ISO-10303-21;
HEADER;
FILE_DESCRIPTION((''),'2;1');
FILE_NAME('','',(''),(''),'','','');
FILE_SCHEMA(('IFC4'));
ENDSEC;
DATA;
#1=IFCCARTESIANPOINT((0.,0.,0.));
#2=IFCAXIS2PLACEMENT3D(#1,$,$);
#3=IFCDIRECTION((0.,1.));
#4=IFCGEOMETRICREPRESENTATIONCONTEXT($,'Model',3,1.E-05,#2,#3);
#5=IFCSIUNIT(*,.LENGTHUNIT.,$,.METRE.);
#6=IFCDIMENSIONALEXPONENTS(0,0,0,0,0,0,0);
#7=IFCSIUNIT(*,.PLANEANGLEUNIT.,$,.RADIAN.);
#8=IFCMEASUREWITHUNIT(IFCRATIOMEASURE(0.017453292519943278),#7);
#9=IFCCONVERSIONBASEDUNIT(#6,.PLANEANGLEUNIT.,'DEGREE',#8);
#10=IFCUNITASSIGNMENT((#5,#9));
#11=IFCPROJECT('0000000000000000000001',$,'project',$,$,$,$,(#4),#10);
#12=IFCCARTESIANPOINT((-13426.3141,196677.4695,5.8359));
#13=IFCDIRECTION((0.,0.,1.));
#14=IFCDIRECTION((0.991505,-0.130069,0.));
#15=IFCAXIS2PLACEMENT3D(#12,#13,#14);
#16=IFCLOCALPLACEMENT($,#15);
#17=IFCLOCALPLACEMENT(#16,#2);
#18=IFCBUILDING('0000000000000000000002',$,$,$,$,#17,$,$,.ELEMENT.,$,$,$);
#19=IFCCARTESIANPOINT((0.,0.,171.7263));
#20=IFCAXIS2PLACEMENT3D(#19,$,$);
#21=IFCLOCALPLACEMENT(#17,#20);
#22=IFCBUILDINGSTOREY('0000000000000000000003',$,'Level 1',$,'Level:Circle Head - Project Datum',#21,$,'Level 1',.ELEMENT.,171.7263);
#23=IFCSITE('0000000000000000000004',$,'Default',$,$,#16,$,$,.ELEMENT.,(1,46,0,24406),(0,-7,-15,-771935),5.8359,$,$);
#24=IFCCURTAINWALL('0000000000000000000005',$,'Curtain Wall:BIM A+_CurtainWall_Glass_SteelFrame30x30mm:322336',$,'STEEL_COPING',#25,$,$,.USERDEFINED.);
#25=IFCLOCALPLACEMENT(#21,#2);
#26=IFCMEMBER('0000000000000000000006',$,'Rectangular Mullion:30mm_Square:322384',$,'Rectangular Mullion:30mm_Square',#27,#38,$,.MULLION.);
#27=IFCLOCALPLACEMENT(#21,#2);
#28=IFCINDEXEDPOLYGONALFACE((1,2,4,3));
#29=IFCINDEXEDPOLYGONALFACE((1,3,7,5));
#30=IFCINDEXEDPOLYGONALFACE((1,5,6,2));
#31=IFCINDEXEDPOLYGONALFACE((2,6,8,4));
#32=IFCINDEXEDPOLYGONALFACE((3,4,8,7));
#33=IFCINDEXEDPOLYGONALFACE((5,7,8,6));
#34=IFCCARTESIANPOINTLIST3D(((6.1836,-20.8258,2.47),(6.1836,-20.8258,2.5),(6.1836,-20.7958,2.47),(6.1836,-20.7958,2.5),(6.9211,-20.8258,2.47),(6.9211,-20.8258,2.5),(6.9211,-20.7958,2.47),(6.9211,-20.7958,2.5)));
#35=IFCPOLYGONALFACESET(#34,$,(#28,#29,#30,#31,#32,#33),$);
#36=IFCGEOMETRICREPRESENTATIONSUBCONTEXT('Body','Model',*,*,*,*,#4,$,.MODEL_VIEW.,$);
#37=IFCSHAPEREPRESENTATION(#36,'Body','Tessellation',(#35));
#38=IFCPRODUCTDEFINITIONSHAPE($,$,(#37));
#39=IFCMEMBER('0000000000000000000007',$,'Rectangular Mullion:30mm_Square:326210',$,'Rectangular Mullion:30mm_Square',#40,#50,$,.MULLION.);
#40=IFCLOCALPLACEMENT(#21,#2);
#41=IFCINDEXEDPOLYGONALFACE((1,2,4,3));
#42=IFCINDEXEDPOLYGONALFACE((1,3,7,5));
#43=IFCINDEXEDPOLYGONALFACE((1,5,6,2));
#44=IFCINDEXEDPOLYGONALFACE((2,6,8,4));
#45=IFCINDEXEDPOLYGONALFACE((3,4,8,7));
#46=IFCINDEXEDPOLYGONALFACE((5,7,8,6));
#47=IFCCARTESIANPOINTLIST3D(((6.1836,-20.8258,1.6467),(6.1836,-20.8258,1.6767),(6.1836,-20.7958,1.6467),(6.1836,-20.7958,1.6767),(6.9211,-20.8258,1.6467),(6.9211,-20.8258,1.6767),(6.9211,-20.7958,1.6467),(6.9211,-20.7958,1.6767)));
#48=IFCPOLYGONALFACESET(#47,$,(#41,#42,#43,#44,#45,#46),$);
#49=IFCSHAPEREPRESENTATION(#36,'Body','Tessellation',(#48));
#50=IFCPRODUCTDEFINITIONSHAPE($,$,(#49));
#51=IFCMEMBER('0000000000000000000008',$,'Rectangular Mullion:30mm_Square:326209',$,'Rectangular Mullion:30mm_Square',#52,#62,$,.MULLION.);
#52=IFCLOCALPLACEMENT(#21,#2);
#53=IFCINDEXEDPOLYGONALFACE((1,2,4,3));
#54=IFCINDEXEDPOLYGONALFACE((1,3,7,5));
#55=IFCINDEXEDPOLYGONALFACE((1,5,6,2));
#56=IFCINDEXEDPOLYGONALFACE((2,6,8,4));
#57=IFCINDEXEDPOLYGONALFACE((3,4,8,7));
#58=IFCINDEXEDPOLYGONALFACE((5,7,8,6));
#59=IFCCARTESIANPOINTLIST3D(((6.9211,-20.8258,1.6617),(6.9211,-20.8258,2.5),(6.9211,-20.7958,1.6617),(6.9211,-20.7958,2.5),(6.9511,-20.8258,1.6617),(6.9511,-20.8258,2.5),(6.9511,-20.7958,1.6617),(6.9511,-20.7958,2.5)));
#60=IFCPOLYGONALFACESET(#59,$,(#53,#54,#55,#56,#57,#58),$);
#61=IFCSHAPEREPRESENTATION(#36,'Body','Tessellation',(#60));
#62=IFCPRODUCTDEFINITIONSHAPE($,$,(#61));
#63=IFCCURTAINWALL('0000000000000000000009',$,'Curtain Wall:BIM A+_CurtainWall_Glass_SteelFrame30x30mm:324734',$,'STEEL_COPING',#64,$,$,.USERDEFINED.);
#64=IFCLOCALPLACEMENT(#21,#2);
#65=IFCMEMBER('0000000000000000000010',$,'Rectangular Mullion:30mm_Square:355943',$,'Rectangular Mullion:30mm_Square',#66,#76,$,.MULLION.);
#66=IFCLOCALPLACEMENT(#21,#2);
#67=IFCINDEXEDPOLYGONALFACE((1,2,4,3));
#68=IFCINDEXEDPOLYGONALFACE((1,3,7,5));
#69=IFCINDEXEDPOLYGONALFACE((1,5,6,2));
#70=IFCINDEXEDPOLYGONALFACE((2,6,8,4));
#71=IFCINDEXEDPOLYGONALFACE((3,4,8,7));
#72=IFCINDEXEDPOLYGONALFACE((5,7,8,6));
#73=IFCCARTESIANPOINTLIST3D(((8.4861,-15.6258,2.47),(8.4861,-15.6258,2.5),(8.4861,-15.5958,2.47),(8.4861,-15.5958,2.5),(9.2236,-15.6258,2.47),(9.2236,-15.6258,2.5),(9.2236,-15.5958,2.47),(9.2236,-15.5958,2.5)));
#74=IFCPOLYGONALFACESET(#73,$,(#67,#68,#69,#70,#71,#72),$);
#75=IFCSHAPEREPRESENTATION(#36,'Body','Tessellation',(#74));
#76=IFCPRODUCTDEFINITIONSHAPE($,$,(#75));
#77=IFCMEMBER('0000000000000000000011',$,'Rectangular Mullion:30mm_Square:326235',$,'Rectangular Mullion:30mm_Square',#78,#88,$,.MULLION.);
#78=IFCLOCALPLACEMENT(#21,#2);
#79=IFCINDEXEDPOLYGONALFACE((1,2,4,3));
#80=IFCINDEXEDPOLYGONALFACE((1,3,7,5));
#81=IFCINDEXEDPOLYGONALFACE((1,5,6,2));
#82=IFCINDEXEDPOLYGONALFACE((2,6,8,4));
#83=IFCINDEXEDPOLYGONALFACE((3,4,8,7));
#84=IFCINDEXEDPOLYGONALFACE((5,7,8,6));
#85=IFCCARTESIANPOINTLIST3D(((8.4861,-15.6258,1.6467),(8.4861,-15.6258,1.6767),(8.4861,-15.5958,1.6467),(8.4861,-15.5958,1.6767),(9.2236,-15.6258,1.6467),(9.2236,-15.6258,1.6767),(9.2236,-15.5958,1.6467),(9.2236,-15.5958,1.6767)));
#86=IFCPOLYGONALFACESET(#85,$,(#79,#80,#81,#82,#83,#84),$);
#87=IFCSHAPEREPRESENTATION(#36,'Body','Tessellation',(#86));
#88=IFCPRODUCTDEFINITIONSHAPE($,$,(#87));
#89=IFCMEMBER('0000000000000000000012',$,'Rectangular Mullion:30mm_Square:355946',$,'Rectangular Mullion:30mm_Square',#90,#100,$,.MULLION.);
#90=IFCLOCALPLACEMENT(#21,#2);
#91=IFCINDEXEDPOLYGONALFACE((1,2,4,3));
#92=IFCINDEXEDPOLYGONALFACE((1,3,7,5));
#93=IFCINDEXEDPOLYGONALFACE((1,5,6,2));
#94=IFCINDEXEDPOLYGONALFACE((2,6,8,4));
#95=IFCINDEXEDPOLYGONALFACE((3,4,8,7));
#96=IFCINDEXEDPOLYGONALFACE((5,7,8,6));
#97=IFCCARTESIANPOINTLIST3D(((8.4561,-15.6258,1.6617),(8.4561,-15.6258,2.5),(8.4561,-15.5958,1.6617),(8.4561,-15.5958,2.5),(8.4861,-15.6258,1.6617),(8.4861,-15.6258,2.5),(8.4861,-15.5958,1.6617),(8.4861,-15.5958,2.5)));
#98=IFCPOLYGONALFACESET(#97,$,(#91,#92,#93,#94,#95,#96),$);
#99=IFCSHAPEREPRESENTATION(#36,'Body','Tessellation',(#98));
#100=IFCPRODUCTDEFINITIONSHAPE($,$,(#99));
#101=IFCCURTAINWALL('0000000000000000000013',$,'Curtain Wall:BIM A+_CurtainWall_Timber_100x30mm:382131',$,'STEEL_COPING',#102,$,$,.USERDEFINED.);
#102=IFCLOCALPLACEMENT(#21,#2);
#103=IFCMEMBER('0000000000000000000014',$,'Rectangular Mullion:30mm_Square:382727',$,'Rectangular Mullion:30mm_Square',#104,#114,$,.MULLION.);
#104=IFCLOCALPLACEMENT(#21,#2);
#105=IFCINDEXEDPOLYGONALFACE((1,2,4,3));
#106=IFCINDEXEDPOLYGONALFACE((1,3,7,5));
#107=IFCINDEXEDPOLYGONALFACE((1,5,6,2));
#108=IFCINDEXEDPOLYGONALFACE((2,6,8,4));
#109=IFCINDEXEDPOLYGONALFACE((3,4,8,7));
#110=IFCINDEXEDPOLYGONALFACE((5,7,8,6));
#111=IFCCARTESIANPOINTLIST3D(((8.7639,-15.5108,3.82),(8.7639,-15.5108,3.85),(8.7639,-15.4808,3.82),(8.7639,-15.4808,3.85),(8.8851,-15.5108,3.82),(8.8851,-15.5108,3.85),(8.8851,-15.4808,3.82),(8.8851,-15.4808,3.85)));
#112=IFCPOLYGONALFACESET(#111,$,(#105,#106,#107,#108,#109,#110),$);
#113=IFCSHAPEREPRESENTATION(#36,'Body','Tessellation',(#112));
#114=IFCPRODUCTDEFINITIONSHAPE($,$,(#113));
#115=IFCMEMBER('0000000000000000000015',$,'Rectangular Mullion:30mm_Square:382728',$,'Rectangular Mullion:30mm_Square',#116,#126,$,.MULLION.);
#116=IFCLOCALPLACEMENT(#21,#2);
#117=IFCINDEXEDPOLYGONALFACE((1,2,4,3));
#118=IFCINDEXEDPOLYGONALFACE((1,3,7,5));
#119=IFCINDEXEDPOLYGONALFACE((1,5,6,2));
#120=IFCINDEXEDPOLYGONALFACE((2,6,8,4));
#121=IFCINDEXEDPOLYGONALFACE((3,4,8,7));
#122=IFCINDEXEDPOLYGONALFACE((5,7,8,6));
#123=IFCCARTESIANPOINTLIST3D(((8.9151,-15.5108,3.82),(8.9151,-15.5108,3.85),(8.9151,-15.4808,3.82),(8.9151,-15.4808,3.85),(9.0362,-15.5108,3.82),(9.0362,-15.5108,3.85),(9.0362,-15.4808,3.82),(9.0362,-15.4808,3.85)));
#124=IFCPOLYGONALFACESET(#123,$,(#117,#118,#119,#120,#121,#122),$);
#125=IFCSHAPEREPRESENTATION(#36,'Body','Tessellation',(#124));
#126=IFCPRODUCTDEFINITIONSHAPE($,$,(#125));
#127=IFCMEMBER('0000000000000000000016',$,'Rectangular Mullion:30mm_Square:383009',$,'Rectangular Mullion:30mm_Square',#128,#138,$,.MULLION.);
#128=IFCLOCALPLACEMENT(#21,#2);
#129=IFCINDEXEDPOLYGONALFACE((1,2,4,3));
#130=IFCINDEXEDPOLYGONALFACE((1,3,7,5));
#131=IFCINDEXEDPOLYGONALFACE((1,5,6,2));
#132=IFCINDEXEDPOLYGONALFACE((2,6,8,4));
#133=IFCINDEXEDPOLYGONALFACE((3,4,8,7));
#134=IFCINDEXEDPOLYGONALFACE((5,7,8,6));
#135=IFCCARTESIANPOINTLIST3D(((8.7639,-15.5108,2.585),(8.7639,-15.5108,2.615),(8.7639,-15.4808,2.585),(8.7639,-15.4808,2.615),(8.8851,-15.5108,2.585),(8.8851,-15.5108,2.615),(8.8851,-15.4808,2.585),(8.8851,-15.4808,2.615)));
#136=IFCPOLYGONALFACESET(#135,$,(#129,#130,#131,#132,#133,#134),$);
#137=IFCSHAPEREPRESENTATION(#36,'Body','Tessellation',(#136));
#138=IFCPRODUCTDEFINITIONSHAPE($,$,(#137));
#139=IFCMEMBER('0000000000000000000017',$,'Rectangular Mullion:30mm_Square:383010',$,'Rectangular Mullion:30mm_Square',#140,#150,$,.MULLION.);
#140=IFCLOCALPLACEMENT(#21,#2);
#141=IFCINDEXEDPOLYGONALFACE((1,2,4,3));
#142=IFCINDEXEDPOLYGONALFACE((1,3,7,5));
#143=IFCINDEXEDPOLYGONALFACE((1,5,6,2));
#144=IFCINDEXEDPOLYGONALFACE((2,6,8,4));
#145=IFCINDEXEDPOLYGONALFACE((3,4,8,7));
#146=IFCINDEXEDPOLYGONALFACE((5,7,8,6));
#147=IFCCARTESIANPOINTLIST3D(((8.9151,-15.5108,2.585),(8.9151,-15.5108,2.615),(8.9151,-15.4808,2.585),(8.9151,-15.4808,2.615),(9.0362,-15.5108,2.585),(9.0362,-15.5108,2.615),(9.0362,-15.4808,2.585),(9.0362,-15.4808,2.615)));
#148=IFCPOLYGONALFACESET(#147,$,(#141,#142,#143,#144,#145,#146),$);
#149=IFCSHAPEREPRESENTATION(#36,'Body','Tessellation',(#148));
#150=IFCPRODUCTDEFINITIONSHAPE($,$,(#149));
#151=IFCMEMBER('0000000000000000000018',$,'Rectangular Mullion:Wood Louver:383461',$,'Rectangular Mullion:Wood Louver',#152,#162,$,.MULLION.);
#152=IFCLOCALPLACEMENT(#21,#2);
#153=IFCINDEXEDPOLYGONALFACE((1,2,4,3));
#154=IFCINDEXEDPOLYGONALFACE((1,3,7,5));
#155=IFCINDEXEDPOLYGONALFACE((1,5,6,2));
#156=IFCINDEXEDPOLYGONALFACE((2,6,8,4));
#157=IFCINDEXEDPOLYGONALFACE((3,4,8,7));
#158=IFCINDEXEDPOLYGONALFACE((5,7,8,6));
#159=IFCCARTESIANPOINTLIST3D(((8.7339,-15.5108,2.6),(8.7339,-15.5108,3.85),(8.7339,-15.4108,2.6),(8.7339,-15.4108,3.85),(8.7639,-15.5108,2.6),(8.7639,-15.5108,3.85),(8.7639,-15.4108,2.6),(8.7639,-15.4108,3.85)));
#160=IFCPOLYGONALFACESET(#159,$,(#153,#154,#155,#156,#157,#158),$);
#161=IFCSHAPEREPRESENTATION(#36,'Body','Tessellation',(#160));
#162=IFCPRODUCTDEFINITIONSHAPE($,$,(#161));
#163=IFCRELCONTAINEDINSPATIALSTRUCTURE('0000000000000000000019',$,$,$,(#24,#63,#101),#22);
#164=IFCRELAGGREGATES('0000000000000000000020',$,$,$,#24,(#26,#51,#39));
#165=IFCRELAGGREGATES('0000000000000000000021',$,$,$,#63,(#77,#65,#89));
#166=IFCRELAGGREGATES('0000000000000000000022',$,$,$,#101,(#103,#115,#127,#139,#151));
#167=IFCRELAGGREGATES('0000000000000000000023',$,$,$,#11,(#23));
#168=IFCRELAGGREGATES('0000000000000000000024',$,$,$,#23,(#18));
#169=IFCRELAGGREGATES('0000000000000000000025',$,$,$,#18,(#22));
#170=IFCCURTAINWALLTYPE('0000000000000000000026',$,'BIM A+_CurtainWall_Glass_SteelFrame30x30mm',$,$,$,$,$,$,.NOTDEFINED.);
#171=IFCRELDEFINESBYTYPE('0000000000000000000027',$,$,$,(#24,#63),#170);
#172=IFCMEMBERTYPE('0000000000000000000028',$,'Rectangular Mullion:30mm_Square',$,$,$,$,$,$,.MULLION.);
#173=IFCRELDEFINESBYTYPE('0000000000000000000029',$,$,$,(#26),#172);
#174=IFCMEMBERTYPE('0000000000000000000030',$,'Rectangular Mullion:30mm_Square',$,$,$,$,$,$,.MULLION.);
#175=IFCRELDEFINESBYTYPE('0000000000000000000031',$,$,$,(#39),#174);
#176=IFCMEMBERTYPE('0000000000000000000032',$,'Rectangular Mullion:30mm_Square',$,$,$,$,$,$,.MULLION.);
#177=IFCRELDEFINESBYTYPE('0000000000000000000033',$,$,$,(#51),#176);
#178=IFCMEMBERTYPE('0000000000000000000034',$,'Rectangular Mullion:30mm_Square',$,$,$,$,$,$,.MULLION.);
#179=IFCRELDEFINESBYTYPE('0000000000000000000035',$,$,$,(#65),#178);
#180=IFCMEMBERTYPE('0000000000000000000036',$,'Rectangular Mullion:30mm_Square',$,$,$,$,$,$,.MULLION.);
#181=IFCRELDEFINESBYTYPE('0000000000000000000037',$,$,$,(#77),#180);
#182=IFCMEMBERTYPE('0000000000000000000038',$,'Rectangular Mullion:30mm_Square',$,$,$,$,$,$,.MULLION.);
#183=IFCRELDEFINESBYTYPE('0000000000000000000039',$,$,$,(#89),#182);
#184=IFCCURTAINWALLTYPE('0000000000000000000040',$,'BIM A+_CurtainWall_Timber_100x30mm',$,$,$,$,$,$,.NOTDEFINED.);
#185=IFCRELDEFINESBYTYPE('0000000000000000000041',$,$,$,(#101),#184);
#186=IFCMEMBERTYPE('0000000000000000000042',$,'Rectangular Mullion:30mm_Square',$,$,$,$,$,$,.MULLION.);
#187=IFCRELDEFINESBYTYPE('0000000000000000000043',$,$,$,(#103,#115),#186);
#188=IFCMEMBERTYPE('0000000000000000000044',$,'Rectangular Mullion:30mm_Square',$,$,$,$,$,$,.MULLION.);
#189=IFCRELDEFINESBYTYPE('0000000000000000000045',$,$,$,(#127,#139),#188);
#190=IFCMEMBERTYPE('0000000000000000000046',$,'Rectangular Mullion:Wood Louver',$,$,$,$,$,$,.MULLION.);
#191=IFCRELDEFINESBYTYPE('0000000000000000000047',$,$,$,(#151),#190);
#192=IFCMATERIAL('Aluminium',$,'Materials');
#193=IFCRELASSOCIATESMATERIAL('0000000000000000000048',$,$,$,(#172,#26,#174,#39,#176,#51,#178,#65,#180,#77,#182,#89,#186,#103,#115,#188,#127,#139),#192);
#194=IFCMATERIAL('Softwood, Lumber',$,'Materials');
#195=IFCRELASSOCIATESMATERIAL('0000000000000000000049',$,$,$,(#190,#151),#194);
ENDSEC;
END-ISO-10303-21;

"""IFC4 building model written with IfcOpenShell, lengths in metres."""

from ifc_helpers import new_model, entity, si_unit, converted_unit, direction, frame, origin, place, context, subcontext, project, spatial, indexed_curve, outline, extrude, source, transform, mapped, material, type_object, type_shapes, element, aggregate, save


model = new_model("IFC4")

# Units and contexts
model_context = context("Model", 3, precision=1e-05, world=origin(), true_north=direction((0.0, 1.0)))
body_context = subcontext(model_context, "Body", "Model", "MODEL_VIEW")
ifc_project = project(units=[si_unit("LENGTHUNIT", "METRE"), converted_unit("PLANEANGLEUNIT", "DEGREE", entity("IfcRatioMeasure", 0.017453292519943278), si_unit("PLANEANGLEUNIT", "RADIAN"), dimensions=[0, 0, 0, 0, 0, 0, 0])], contexts=[model_context])

# Site, building, storey
site_placement = place(None, frame((-13426.3141, 196677.4695, 5.8359), z_axis=(0.0, 0.0, 1.0), x_axis=(0.991505, -0.130069, 0.0)))
site = spatial("IfcSite", under=ifc_project, at=site_placement, Name="Default", CompositionType="ELEMENT", RefLatitude=(1, 46, 0, 24406), RefLongitude=(0, -7, -15, -771935), RefElevation=5.8359)
building_placement = place(site_placement, origin())
building = spatial("IfcBuilding", under=site, at=building_placement, CompositionType="ELEMENT")
storey_placement = place(building_placement, frame((0.0, 0.0, 171.7263)))
storey = spatial("IfcBuildingStorey", under=building, at=storey_placement, Name="Level 1", ObjectType="Level:Circle Head - Project Datum", LongName="Level 1", CompositionType="ELEMENT", Elevation=171.7263)

# Curtain walls, members
curtain_wall_type_1 = type_object("IfcCurtainWallType", Name="BIM A+_CurtainWall_Glass_SteelFrame30x30mm", PredefinedType="NOTDEFINED")
curtain_wall_1_placement = place(storey_placement, frame((0.0, 0.0, -171.7263)))
curtain_wall_1 = element("IfcCurtainWall", 1, at=curtain_wall_1_placement, inside=storey, type_object=curtain_wall_type_1, Name="Curtain Wall:BIM A+_CurtainWall_Glass_SteelFrame30x30mm:322336", ObjectType="STEEL_COPING", PredefinedType="USERDEFINED")
ifc_material_1 = material(Name="Aluminium", Category="Materials")
member_type_1 = type_object("IfcMemberType", Name="Rectangular Mullion:30mm_Square", PredefinedType="MULLION", material=ifc_material_1)
shared_shape_1 = source(origin(), body_context, "Body", "SweptSolid", [
    extrude(outline(indexed_curve([(-0.015, -0.015), (0.015, -0.015), (0.015, 0.015), (-0.015, 0.015), (-0.015, -0.015)], self_intersect=False)), frame((-0.015, 0.0, -0.7375), z_axis=(0.0, 0.0, 1.0), x_axis=(0.0, -1.0, 0.0)), (0.0, 0.0, 1.0), 0.7375),
])
type_shapes(member_type_1, [shared_shape_1])
member_1_placement = place(curtain_wall_1_placement, frame((6.9211, -20.8108, 174.2263), z_axis=(1.0, 0.0, 0.0), x_axis=(0.0, 0.0, 1.0)))
member_1 = element("IfcMember", 2, at=member_1_placement, type_object=member_type_1, material=ifc_material_1, Name="Rectangular Mullion:30mm_Square:322384", ObjectType="Rectangular Mullion:30mm_Square", PredefinedType="MULLION", context=body_context, shape_type="MappedRepresentation", body=[
    mapped(shared_shape_1, transform((0.0, 0.0, 0.0), scale=1.0)),
])
member_type_2 = type_object("IfcMemberType", Name="Rectangular Mullion:30mm_Square", PredefinedType="MULLION", material=ifc_material_1)
shared_shape_2 = source(origin(), body_context, "Body", "SweptSolid", [
    extrude(outline(indexed_curve([(-0.015, -0.015), (0.015, -0.015), (0.015, 0.015), (-0.015, 0.015), (-0.015, -0.015)], self_intersect=False)), frame((0.0, 0.0, -0.7375), z_axis=(0.0, 0.0, 1.0), x_axis=(0.0, -1.0, 0.0)), (0.0, 0.0, 1.0), 0.7375),
])
type_shapes(member_type_2, [shared_shape_2])
member_2_placement = place(curtain_wall_1_placement, frame((6.9211, -20.8108, 173.3879), z_axis=(1.0, 0.0, 0.0), x_axis=(0.0, 0.0, 1.0)))
member_2 = element("IfcMember", 3, at=member_2_placement, type_object=member_type_2, material=ifc_material_1, Name="Rectangular Mullion:30mm_Square:326210", ObjectType="Rectangular Mullion:30mm_Square", PredefinedType="MULLION", context=body_context, shape_type="MappedRepresentation", body=[
    mapped(shared_shape_2, transform((0.0, 0.0, 0.0), scale=1.0)),
])
member_type_3 = type_object("IfcMemberType", Name="Rectangular Mullion:30mm_Square", PredefinedType="MULLION", material=ifc_material_1)
shared_shape_3 = source(origin(), body_context, "Body", "SweptSolid", [
    extrude(outline(indexed_curve([(-0.015, -0.015), (0.015, -0.015), (0.015, 0.015), (-0.015, 0.015), (-0.015, -0.015)], self_intersect=False)), frame((0.0, 0.0, -0.8383), z_axis=(0.0, 0.0, 1.0), x_axis=(0.0, -1.0, 0.0)), (0.0, 0.0, 1.0), 0.8383),
])
type_shapes(member_type_3, [shared_shape_3])
member_3_placement = place(curtain_wall_1_placement, frame((6.9361, -20.8108, 173.3879), z_axis=(0.0, 0.0, -1.0), x_axis=(1.0, 0.0, 0.0)))
member_3 = element("IfcMember", 4, at=member_3_placement, type_object=member_type_3, material=ifc_material_1, Name="Rectangular Mullion:30mm_Square:326209", ObjectType="Rectangular Mullion:30mm_Square", PredefinedType="MULLION", context=body_context, shape_type="MappedRepresentation", body=[
    mapped(shared_shape_3, transform((0.0, 0.0, 0.0), scale=1.0)),
])
curtain_wall_2_placement = place(storey_placement, frame((0.0, 0.0, -171.7263)))
curtain_wall_2 = element("IfcCurtainWall", 5, at=curtain_wall_2_placement, inside=storey, type_object=curtain_wall_type_1, Name="Curtain Wall:BIM A+_CurtainWall_Glass_SteelFrame30x30mm:324734", ObjectType="STEEL_COPING", PredefinedType="USERDEFINED")
member_type_4 = type_object("IfcMemberType", Name="Rectangular Mullion:30mm_Square", PredefinedType="MULLION", material=ifc_material_1)
shared_shape_4 = source(origin(), body_context, "Body", "SweptSolid", [
    extrude(outline(indexed_curve([(-0.015, -0.015), (0.015, -0.015), (0.015, 0.015), (-0.015, 0.015), (-0.015, -0.015)], self_intersect=False)), frame((-0.015, 0.0, -0.7375), z_axis=(0.0, 0.0, 1.0), x_axis=(0.0, -1.0, 0.0)), (0.0, 0.0, 1.0), 0.7375),
])
type_shapes(member_type_4, [shared_shape_4])
member_4_placement = place(curtain_wall_2_placement, frame((8.4861, -15.6108, 174.2263), z_axis=(-1.0, 0.0, 0.0), x_axis=(0.0, 0.0, 1.0)))
member_4 = element("IfcMember", 6, at=member_4_placement, type_object=member_type_4, material=ifc_material_1, Name="Rectangular Mullion:30mm_Square:355943", ObjectType="Rectangular Mullion:30mm_Square", PredefinedType="MULLION", context=body_context, shape_type="MappedRepresentation", body=[
    mapped(shared_shape_4, transform((0.0, 0.0, 0.0), scale=1.0)),
])
member_type_5 = type_object("IfcMemberType", Name="Rectangular Mullion:30mm_Square", PredefinedType="MULLION", material=ifc_material_1)
shared_shape_5 = source(origin(), body_context, "Body", "SweptSolid", [
    extrude(outline(indexed_curve([(-0.015, -0.015), (0.015, -0.015), (0.015, 0.015), (-0.015, 0.015), (-0.015, -0.015)], self_intersect=False)), frame((0.0, 0.0, -0.7375), z_axis=(0.0, 0.0, 1.0), x_axis=(0.0, -1.0, 0.0)), (0.0, 0.0, 1.0), 0.7375),
])
type_shapes(member_type_5, [shared_shape_5])
member_5_placement = place(curtain_wall_2_placement, frame((8.4861, -15.6108, 173.3879), z_axis=(-1.0, 0.0, 0.0), x_axis=(0.0, 0.0, 1.0)))
member_5 = element("IfcMember", 7, at=member_5_placement, type_object=member_type_5, material=ifc_material_1, Name="Rectangular Mullion:30mm_Square:326235", ObjectType="Rectangular Mullion:30mm_Square", PredefinedType="MULLION", context=body_context, shape_type="MappedRepresentation", body=[
    mapped(shared_shape_5, transform((0.0, 0.0, 0.0), scale=1.0)),
])
member_type_6 = type_object("IfcMemberType", Name="Rectangular Mullion:30mm_Square", PredefinedType="MULLION", material=ifc_material_1)
shared_shape_6 = source(origin(), body_context, "Body", "SweptSolid", [
    extrude(outline(indexed_curve([(-0.015, -0.015), (0.015, -0.015), (0.015, 0.015), (-0.015, 0.015), (-0.015, -0.015)], self_intersect=False)), frame((0.0, 0.0, -0.8383), z_axis=(0.0, 0.0, 1.0), x_axis=(0.0, -1.0, 0.0)), (0.0, 0.0, 1.0), 0.8383),
])
type_shapes(member_type_6, [shared_shape_6])
member_6_placement = place(curtain_wall_2_placement, frame((8.4711, -15.6108, 173.3879), z_axis=(0.0, 0.0, -1.0), x_axis=(-1.0, 0.0, 0.0)))
member_6 = element("IfcMember", 8, at=member_6_placement, type_object=member_type_6, material=ifc_material_1, Name="Rectangular Mullion:30mm_Square:355946", ObjectType="Rectangular Mullion:30mm_Square", PredefinedType="MULLION", context=body_context, shape_type="MappedRepresentation", body=[
    mapped(shared_shape_6, transform((0.0, 0.0, 0.0), scale=1.0)),
])
curtain_wall_type_2 = type_object("IfcCurtainWallType", Name="BIM A+_CurtainWall_Timber_100x30mm", PredefinedType="NOTDEFINED")
curtain_wall_3_placement = place(storey_placement, frame((0.0, 0.0, -171.7263)))
curtain_wall_3 = element("IfcCurtainWall", 9, at=curtain_wall_3_placement, inside=storey, type_object=curtain_wall_type_2, Name="Curtain Wall:BIM A+_CurtainWall_Timber_100x30mm:382131", ObjectType="STEEL_COPING", PredefinedType="USERDEFINED")
member_type_7 = type_object("IfcMemberType", Name="Rectangular Mullion:30mm_Square", PredefinedType="MULLION", material=ifc_material_1)
shared_shape_7 = source(origin(), body_context, "Body", "SweptSolid", [
    extrude(outline(indexed_curve([(-0.015, -0.015), (0.015, -0.015), (0.015, 0.015), (-0.015, 0.015), (-0.015, -0.015)], self_intersect=False)), frame((-0.015, 0.0, -0.1212), z_axis=(0.0, 0.0, 1.0), x_axis=(0.0, -1.0, 0.0)), (0.0, 0.0, 1.0), 0.1212),
])
type_shapes(member_type_7, [shared_shape_7])
member_7_placement = place(curtain_wall_3_placement, frame((8.8851, -15.4958, 175.5763), z_axis=(1.0, 0.0, 0.0), x_axis=(0.0, 0.0, 1.0)))
member_7 = element("IfcMember", 10, at=member_7_placement, type_object=member_type_7, material=ifc_material_1, Name="Rectangular Mullion:30mm_Square:382727", ObjectType="Rectangular Mullion:30mm_Square", PredefinedType="MULLION", context=body_context, shape_type="MappedRepresentation", body=[
    mapped(shared_shape_7, transform((0.0, 0.0, 0.0), scale=1.0)),
])
member_8_placement = place(curtain_wall_3_placement, frame((9.0362, -15.4958, 175.5763), z_axis=(1.0, 0.0, 0.0), x_axis=(0.0, 0.0, 1.0)))
member_8 = element("IfcMember", 11, at=member_8_placement, type_object=member_type_7, material=ifc_material_1, Name="Rectangular Mullion:30mm_Square:382728", ObjectType="Rectangular Mullion:30mm_Square", PredefinedType="MULLION", context=body_context, shape_type="MappedRepresentation", body=[
    mapped(shared_shape_7, transform((0.0, 0.0, 0.0), scale=1.0)),
])
member_type_8 = type_object("IfcMemberType", Name="Rectangular Mullion:30mm_Square", PredefinedType="MULLION", material=ifc_material_1)
shared_shape_8 = source(origin(), body_context, "Body", "SweptSolid", [
    extrude(outline(indexed_curve([(-0.015, -0.015), (0.015, -0.015), (0.015, 0.015), (-0.015, 0.015), (-0.015, -0.015)], self_intersect=False)), frame((0.0, 0.0, -0.1212), z_axis=(0.0, 0.0, 1.0), x_axis=(0.0, -1.0, 0.0)), (0.0, 0.0, 1.0), 0.1212),
])
type_shapes(member_type_8, [shared_shape_8])
member_9_placement = place(curtain_wall_3_placement, frame((8.8851, -15.4958, 174.3263), z_axis=(1.0, 0.0, 0.0), x_axis=(0.0, 0.0, 1.0)))
member_9 = element("IfcMember", 12, at=member_9_placement, type_object=member_type_8, material=ifc_material_1, Name="Rectangular Mullion:30mm_Square:383009", ObjectType="Rectangular Mullion:30mm_Square", PredefinedType="MULLION", context=body_context, shape_type="MappedRepresentation", body=[
    mapped(shared_shape_8, transform((0.0, 0.0, 0.0), scale=1.0)),
])
member_10_placement = place(curtain_wall_3_placement, frame((9.0362, -15.4958, 174.3263), z_axis=(1.0, 0.0, 0.0), x_axis=(0.0, 0.0, 1.0)))
member_10 = element("IfcMember", 13, at=member_10_placement, type_object=member_type_8, material=ifc_material_1, Name="Rectangular Mullion:30mm_Square:383010", ObjectType="Rectangular Mullion:30mm_Square", PredefinedType="MULLION", context=body_context, shape_type="MappedRepresentation", body=[
    mapped(shared_shape_8, transform((0.0, 0.0, 0.0), scale=1.0)),
])
ifc_material_2 = material(Name="Softwood, Lumber", Category="Materials")
member_type_9 = type_object("IfcMemberType", Name="Rectangular Mullion:Wood Louver", PredefinedType="MULLION", material=ifc_material_2)
shared_shape_9 = source(origin(), body_context, "Body", "SweptSolid", [
    extrude(outline(indexed_curve([(-0.05, -0.015), (0.05, -0.015), (0.05, 0.015), (-0.05, 0.015), (-0.05, -0.015)], self_intersect=False)), frame((0.0, -0.035, -1.25), z_axis=(0.0, 0.0, 1.0), x_axis=(0.0, -1.0, 0.0)), (0.0, 0.0, 1.0), 1.25),
])
type_shapes(member_type_9, [shared_shape_9])
member_11_placement = place(curtain_wall_3_placement, frame((8.7489, -15.4958, 174.3263), z_axis=(0.0, 0.0, -1.0), x_axis=(1.0, 0.0, 0.0)))
member_11 = element("IfcMember", 14, at=member_11_placement, type_object=member_type_9, material=ifc_material_2, Name="Rectangular Mullion:Wood Louver:383461", ObjectType="Rectangular Mullion:Wood Louver", PredefinedType="MULLION", context=body_context, shape_type="MappedRepresentation", body=[
    mapped(shared_shape_9, transform((0.0, 0.0, 0.0), scale=1.0)),
])

aggregate(curtain_wall_1, [member_1, member_3, member_2])
aggregate(curtain_wall_2, [member_5, member_4, member_6])
aggregate(curtain_wall_3, [member_7, member_8, member_9, member_10, member_11])

save(model, "model.ifc")
